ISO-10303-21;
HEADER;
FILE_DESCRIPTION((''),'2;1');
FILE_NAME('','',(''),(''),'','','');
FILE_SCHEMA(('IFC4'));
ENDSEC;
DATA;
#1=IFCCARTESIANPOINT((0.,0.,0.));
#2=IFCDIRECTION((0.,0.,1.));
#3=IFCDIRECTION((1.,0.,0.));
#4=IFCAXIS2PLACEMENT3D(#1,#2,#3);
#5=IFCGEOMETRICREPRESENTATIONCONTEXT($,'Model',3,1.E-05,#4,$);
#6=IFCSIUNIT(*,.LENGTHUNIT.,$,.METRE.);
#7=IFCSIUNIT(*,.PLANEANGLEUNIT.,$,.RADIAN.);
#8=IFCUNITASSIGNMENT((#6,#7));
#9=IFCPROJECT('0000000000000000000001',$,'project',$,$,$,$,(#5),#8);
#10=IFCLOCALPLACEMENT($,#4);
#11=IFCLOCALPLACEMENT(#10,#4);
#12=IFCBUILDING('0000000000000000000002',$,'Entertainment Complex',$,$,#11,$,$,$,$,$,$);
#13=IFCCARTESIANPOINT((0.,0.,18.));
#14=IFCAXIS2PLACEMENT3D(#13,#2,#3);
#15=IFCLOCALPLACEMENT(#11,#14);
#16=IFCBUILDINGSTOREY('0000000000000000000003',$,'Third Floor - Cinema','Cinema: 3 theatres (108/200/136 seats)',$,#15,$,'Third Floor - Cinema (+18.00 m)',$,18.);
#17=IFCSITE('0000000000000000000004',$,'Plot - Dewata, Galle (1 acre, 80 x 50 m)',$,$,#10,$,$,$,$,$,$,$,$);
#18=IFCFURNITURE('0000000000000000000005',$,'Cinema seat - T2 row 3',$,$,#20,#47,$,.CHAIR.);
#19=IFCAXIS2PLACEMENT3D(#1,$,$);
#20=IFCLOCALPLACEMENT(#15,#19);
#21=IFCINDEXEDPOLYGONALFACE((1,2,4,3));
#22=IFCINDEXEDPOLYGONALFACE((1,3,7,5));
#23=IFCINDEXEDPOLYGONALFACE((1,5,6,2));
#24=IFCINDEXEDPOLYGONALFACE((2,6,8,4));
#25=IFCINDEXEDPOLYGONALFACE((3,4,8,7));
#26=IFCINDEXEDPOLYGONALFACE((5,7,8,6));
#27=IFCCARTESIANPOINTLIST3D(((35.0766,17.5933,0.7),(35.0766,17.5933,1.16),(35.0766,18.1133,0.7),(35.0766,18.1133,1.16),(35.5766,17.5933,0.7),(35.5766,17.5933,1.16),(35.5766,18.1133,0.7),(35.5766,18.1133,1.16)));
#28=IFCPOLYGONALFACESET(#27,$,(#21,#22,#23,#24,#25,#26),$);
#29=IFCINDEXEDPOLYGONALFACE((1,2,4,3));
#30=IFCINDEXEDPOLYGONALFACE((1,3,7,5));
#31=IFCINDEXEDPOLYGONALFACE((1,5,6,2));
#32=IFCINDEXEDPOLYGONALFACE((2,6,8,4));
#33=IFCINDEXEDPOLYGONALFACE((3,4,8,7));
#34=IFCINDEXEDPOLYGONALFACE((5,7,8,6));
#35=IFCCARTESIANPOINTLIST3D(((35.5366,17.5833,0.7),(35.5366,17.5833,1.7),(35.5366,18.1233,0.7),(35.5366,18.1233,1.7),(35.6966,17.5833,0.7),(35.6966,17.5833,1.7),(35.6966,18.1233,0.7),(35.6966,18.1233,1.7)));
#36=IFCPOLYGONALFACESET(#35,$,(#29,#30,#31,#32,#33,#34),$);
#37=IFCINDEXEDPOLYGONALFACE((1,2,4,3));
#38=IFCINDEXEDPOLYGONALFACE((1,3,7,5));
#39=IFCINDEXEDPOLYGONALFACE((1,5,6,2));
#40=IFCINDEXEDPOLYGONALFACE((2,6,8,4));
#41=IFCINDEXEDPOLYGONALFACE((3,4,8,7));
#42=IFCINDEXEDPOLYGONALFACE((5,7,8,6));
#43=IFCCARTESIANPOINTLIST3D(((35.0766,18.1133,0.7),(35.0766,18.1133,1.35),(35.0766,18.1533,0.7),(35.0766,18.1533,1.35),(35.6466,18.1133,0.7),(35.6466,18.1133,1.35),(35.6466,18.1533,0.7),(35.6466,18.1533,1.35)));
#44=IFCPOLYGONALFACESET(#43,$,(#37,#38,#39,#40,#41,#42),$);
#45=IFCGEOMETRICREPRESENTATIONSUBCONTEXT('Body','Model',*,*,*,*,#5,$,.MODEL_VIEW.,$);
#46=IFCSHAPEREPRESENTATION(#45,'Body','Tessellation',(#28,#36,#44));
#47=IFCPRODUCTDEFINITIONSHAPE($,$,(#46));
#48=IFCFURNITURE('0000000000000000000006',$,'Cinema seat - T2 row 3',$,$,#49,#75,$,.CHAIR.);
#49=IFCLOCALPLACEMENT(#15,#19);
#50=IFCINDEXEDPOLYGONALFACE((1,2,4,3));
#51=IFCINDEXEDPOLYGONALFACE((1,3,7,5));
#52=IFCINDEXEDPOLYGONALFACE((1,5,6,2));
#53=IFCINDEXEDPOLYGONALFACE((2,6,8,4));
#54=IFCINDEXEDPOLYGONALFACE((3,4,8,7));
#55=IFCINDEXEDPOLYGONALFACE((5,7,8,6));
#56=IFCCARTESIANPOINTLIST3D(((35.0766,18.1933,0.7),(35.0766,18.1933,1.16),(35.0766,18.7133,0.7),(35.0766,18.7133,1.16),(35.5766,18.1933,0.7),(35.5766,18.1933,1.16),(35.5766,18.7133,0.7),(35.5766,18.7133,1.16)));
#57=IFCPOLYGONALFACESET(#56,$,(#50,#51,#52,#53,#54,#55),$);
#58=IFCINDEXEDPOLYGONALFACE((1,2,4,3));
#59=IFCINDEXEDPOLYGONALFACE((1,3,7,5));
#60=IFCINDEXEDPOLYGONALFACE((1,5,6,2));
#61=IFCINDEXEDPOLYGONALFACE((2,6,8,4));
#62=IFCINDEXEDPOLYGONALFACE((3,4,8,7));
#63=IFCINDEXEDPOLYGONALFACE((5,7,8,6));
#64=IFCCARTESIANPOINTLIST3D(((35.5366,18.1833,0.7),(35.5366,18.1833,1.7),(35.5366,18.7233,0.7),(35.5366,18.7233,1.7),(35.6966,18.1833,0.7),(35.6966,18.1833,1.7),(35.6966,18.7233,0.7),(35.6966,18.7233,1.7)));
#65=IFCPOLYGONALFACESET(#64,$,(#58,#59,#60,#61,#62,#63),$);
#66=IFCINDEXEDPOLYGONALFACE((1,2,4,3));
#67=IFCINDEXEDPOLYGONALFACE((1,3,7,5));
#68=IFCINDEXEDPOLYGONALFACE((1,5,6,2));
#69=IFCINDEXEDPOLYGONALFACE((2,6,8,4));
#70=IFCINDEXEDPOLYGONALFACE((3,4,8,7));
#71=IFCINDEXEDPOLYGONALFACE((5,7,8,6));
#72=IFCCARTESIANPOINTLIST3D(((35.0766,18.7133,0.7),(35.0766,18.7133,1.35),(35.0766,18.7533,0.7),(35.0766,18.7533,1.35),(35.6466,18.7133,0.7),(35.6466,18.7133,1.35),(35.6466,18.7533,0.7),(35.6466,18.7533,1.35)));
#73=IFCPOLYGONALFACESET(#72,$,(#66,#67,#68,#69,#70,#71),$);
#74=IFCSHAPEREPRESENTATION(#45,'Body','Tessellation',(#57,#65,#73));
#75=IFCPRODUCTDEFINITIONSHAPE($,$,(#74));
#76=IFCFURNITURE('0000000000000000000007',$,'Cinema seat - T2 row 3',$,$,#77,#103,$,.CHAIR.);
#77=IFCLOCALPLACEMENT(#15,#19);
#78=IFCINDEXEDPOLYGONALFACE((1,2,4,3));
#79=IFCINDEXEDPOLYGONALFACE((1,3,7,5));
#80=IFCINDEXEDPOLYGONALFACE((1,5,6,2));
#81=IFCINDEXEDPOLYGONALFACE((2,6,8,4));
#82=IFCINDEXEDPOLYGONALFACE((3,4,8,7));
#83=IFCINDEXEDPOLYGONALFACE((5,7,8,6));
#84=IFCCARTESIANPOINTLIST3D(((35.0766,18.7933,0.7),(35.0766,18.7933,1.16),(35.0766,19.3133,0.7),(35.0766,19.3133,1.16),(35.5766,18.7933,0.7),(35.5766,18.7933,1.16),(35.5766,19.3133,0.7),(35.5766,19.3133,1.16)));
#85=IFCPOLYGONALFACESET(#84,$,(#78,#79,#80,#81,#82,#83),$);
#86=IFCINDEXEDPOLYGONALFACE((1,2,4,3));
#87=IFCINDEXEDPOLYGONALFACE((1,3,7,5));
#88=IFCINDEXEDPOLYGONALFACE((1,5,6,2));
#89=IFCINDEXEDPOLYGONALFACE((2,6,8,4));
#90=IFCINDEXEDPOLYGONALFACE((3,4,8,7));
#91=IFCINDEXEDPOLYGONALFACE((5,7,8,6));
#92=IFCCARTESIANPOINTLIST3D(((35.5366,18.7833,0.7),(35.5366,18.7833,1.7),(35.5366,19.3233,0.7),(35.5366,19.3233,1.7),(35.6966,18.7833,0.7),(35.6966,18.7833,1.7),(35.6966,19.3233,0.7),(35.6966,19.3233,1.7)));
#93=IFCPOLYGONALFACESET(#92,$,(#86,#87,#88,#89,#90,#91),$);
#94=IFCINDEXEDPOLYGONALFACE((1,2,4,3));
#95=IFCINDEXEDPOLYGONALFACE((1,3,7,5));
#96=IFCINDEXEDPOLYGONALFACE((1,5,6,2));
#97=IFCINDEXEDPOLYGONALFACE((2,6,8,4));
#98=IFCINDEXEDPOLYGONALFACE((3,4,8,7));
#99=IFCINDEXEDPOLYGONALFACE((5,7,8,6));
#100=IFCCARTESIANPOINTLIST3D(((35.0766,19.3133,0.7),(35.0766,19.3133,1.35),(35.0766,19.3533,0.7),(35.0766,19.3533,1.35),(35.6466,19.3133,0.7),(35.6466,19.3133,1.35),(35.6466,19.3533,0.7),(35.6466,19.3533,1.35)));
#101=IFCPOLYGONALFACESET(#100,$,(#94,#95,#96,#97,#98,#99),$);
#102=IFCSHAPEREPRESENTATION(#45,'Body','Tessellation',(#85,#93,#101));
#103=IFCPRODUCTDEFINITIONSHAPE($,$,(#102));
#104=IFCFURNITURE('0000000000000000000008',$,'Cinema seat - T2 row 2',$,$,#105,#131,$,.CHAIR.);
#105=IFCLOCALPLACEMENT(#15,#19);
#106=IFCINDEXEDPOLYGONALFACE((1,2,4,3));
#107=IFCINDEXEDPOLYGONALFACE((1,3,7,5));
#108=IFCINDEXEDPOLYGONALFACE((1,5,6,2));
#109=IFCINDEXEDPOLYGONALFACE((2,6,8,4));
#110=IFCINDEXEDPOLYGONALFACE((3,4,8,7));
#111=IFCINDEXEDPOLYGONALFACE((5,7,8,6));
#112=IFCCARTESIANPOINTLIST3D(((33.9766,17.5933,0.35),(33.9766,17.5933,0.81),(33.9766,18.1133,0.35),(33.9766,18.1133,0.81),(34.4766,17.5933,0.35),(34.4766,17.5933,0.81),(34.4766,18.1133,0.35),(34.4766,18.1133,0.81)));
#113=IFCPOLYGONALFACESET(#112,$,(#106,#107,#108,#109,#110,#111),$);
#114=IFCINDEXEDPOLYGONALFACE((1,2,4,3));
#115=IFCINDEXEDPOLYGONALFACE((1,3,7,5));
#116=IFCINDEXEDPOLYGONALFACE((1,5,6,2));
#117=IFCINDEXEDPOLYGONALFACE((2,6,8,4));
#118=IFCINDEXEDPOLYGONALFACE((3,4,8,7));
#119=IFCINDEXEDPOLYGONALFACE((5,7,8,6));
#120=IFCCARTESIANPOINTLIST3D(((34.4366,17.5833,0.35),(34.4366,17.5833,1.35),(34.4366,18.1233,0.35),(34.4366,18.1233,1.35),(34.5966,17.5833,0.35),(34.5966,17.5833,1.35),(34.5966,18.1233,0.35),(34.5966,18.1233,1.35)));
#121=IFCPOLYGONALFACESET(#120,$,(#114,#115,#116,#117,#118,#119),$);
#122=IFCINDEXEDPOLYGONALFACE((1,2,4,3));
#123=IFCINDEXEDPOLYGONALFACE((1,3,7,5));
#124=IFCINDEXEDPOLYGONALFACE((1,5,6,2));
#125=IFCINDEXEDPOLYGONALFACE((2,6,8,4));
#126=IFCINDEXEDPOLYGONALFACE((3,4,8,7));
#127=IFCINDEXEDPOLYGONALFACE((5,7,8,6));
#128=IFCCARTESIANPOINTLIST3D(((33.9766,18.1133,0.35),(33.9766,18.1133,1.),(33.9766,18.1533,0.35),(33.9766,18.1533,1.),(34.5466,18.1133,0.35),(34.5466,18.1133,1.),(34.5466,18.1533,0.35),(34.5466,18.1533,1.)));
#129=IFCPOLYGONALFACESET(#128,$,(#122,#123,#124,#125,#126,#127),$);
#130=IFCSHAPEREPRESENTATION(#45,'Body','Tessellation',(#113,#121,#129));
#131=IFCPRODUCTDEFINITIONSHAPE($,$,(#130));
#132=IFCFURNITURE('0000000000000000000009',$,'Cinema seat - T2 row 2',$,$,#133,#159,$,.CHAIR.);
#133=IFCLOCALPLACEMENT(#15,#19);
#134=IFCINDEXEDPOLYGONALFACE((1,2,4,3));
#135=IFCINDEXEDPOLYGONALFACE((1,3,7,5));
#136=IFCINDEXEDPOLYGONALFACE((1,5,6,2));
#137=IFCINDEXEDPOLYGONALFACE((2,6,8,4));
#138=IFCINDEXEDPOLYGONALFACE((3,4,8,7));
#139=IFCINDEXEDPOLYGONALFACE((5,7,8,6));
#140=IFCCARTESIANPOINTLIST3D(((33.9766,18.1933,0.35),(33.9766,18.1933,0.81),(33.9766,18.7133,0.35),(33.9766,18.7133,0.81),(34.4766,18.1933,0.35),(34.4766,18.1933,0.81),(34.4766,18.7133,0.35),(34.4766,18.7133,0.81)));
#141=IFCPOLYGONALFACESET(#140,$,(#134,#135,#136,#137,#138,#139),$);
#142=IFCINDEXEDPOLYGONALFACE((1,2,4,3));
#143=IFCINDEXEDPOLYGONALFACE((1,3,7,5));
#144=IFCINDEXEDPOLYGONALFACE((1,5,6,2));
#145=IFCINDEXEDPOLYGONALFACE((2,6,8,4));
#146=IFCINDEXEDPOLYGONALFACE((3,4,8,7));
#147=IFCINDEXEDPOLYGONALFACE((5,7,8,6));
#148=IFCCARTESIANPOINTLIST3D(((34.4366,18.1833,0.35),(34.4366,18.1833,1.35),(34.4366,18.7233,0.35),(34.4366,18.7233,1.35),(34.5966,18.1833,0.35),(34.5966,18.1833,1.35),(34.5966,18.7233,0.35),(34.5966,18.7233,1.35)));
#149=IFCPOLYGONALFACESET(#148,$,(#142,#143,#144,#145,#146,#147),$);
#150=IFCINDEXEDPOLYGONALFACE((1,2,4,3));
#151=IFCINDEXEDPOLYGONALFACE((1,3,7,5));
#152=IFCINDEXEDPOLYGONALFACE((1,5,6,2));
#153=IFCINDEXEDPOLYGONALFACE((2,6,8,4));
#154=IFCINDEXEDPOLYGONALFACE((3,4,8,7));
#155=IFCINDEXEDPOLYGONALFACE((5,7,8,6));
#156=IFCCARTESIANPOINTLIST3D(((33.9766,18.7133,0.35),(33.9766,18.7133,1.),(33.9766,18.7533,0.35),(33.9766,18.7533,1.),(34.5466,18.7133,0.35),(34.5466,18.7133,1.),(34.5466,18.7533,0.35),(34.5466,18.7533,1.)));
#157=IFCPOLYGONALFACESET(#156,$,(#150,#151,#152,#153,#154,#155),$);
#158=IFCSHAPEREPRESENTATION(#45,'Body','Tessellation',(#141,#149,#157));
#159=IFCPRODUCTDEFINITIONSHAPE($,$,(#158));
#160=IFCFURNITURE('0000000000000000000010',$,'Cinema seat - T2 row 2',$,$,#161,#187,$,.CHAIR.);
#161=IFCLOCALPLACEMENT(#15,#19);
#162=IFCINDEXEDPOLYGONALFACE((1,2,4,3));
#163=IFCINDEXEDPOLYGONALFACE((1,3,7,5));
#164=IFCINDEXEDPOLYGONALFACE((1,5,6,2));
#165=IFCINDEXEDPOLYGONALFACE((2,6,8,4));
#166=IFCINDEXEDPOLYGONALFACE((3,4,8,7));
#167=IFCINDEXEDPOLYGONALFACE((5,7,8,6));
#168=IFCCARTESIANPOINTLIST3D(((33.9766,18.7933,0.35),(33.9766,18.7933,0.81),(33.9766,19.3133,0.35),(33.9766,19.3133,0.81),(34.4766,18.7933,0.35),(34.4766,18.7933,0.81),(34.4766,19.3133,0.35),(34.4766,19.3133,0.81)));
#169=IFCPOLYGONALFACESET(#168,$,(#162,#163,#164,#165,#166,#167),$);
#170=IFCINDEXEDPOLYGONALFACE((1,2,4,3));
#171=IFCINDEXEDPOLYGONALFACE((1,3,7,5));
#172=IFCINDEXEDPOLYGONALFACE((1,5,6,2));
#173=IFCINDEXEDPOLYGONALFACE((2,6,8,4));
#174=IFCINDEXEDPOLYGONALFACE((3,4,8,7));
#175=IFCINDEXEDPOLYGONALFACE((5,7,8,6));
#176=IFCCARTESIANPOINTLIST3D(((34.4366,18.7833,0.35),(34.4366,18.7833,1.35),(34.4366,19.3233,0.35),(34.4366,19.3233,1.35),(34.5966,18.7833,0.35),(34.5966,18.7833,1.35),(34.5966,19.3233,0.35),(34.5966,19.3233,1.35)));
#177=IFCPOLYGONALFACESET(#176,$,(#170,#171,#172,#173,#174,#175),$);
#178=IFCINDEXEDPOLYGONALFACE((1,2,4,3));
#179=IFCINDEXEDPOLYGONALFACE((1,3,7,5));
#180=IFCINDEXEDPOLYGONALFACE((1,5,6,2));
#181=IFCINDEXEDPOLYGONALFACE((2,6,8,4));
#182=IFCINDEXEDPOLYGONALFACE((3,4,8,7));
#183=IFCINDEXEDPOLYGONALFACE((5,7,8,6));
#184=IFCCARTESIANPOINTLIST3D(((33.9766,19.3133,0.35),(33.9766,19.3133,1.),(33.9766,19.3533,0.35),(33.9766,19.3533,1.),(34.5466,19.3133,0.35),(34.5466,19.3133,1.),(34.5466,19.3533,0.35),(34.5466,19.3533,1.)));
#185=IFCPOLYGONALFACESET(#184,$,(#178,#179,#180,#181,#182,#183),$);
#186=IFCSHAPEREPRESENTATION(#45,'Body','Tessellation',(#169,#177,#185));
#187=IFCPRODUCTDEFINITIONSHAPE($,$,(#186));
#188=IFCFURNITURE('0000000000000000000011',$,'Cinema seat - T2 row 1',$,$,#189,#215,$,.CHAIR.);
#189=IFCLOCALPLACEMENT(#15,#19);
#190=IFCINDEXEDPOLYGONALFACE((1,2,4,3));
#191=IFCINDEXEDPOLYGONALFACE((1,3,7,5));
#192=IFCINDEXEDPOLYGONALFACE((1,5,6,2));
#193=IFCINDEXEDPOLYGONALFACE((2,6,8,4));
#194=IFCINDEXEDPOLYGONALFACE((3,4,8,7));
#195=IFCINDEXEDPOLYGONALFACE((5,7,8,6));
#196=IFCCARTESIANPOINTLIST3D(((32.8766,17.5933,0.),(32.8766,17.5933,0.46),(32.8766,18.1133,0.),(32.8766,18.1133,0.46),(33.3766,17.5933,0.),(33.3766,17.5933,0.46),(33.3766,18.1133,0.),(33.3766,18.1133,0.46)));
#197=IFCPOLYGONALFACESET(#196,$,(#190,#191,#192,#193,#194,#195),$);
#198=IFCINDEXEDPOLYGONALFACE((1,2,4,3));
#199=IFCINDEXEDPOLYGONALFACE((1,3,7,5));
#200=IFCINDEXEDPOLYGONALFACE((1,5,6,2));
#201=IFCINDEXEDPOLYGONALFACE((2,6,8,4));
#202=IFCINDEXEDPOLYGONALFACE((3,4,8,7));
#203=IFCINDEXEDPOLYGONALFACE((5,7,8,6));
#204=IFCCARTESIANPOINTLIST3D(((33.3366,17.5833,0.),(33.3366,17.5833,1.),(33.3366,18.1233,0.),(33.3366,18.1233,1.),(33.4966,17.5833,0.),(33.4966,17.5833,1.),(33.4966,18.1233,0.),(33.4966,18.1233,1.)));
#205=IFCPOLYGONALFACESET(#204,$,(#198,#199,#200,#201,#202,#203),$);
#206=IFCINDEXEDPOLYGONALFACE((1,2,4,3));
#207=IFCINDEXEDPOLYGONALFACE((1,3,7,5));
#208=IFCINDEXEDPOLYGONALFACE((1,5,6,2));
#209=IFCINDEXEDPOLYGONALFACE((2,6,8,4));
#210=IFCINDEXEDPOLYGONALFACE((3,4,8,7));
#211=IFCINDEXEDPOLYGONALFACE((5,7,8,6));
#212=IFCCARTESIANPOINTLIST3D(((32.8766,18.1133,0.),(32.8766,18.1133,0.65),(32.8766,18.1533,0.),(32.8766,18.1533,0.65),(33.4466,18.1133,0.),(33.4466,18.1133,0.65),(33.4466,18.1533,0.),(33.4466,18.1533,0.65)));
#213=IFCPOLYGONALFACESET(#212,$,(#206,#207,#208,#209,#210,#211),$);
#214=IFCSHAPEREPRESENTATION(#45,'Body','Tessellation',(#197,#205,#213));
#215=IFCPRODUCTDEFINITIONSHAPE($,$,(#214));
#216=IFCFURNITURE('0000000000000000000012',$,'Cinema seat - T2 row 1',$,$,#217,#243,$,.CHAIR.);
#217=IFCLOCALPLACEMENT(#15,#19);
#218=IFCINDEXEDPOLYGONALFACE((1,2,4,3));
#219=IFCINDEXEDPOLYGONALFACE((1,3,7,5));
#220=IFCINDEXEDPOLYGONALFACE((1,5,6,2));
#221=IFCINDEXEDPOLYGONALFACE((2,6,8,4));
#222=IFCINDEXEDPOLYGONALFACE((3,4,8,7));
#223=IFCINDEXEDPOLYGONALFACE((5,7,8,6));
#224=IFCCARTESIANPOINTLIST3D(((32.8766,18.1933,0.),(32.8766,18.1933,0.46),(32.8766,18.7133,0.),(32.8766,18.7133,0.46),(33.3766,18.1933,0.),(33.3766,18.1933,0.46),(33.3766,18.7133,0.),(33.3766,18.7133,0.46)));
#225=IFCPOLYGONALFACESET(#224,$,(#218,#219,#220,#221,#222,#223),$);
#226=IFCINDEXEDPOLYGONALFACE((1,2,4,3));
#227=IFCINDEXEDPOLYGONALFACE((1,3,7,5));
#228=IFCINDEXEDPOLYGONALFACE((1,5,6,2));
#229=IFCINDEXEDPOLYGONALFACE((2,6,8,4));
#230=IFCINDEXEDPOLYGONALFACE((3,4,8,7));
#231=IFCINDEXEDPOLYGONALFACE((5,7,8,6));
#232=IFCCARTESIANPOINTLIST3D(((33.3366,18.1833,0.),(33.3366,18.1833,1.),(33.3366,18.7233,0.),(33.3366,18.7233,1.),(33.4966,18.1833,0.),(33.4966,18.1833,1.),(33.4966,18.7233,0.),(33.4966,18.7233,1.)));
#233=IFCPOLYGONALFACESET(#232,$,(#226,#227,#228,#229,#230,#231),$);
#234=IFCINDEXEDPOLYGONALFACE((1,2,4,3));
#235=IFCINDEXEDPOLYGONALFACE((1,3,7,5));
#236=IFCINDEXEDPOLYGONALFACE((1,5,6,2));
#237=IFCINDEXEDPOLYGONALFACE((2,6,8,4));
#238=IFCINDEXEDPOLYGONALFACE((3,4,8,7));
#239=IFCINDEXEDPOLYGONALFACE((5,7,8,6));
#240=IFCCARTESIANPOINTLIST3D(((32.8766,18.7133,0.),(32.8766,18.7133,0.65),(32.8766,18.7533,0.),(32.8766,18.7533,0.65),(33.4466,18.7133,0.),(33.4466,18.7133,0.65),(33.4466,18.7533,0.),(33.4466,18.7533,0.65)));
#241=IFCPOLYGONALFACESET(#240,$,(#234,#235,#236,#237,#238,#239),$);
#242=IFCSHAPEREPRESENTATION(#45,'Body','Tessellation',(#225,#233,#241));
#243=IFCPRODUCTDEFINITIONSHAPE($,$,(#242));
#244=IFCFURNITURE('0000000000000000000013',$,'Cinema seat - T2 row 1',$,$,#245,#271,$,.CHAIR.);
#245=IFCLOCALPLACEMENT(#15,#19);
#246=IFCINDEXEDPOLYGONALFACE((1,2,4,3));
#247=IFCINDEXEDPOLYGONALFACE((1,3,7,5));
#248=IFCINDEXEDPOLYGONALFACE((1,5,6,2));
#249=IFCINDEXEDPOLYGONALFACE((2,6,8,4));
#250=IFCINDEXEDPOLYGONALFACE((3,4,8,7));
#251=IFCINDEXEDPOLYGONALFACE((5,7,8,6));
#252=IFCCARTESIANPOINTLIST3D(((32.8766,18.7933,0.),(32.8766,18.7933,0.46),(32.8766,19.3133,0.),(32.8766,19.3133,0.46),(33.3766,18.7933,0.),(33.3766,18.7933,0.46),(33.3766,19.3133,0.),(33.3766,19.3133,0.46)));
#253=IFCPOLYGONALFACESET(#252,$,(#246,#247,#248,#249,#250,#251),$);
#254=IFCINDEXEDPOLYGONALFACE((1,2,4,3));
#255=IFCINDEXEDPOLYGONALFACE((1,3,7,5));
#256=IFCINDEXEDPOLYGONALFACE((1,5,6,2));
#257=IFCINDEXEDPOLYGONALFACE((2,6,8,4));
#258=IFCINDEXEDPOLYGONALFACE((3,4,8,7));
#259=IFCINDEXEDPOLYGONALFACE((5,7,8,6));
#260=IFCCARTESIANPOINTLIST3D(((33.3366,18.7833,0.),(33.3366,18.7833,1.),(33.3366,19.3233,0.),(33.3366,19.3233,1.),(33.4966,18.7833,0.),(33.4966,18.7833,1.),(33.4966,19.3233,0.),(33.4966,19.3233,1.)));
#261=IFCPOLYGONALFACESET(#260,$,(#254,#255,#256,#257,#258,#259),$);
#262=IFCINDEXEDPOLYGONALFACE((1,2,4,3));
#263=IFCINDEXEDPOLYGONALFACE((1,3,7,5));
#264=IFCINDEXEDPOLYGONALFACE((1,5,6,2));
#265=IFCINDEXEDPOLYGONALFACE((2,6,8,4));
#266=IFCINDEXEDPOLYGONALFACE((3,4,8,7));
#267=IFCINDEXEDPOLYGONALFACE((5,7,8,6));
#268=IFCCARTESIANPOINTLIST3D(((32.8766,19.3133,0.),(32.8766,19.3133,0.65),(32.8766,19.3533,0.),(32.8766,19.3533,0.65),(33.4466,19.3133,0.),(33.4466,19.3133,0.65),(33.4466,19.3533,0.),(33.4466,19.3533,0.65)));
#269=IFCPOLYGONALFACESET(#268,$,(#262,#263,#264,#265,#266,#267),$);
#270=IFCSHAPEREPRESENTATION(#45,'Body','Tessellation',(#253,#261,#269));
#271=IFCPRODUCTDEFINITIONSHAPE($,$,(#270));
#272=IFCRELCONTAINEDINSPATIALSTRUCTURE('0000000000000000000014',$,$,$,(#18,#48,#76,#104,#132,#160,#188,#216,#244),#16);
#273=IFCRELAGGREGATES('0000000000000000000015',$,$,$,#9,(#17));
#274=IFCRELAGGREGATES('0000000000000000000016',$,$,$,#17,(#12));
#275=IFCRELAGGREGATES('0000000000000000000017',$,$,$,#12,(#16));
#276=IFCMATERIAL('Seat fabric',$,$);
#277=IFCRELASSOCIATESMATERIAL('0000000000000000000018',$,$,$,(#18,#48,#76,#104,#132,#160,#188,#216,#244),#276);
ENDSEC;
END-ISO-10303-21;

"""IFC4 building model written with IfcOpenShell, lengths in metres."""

from ifc_helpers import new_model, si_unit, frame, origin_with_axes, place, context, subcontext, project, spatial, polyline, outline, extrude, material, element, save


model = new_model("IFC4")

# Units and contexts
model_context = context("Model", 3, precision=1e-05, world=origin_with_axes())
body_context = subcontext(model_context, "Body", "Model", "MODEL_VIEW")
ifc_project = project(units=[si_unit("LENGTHUNIT", "METRE"), si_unit("PLANEANGLEUNIT", "RADIAN")], contexts=[model_context])

# Site, building, storey
site_placement = place(None, origin_with_axes())
site = spatial("IfcSite", under=ifc_project, at=site_placement, Name="Plot - Dewata, Galle (1 acre, 80 x 50 m)")
building_placement = place(site_placement, origin_with_axes())
building = spatial("IfcBuilding", under=site, at=building_placement, Name="Entertainment Complex")
storey_placement = place(building_placement, frame((0.0, 0.0, 18.0), z_axis=(0.0, 0.0, 1.0), x_axis=(1.0, 0.0, 0.0)))
storey = spatial("IfcBuildingStorey", under=building, at=storey_placement, Name="Third Floor - Cinema", Description="Cinema: 3 theatres (108/200/136 seats)", LongName="Third Floor - Cinema (+18.00 m)", Elevation=18.0)

# Furniture
ifc_material_1 = material(Name="Seat fabric")
for number, where, z_axis, x_axis, name in (
    (1, (35.6966, 17.8533, 0.7), (0.0, 0.0, 1.0), (1.0, 0.0, 0.0), "Cinema seat - T2 row 3"),
    (2, (35.6966, 18.4533, 0.7), (0.0, 0.0, 1.0), (1.0, 0.0, 0.0), "Cinema seat - T2 row 3"),
    (3, (35.6966, 19.0533, 0.7), (0.0, 0.0, 1.0), (1.0, 0.0, 0.0), "Cinema seat - T2 row 3"),
    (4, (34.5966, 17.8533, 0.35), (0.0, 0.0, 1.0), (1.0, 0.0, 0.0), "Cinema seat - T2 row 2"),
    (5, (34.5966, 18.4533, 0.35), (0.0, 0.0, 1.0), (1.0, 0.0, 0.0), "Cinema seat - T2 row 2"),
    (6, (34.5966, 19.0533, 0.35), (0.0, 0.0, 1.0), (1.0, 0.0, 0.0), "Cinema seat - T2 row 2"),
    (7, (33.4966, 17.8533, 0.0), (0.0, 0.0, 1.0), (1.0, 0.0, 0.0), "Cinema seat - T2 row 1"),
    (8, (33.4966, 18.4533, 0.0), (0.0, 0.0, 1.0), (1.0, 0.0, 0.0), "Cinema seat - T2 row 1"),
    (9, (33.4966, 19.0533, 0.0), (0.0, 0.0, 1.0), (1.0, 0.0, 0.0), "Cinema seat - T2 row 1"),
):
    element("IfcFurniture", number, at=place(storey_placement, frame(where, z_axis=z_axis, x_axis=x_axis)), inside=storey, material=ifc_material_1, Name=name, PredefinedType="CHAIR", context=body_context, shape_type="SweptSolid", body=[
        extrude(outline(polyline([(-0.62, -0.26), (-0.12, -0.26), (-0.12, 0.26), (-0.62, 0.26), (-0.62, -0.26)])), origin_with_axes(), (0.0, 0.0, 1.0), 0.46),
        extrude(outline(polyline([(-0.16, -0.27), (0.0, -0.27), (0.0, 0.27), (-0.16, 0.27), (-0.16, -0.27)])), origin_with_axes(), (0.0, 0.0, 1.0), 1.0),
        extrude(outline(polyline([(-0.62, 0.26), (-0.05, 0.26), (-0.05, 0.3), (-0.62, 0.3), (-0.62, 0.26)])), origin_with_axes(), (0.0, 0.0, 1.0), 0.65),
    ])

save(model, "model.ifc")
